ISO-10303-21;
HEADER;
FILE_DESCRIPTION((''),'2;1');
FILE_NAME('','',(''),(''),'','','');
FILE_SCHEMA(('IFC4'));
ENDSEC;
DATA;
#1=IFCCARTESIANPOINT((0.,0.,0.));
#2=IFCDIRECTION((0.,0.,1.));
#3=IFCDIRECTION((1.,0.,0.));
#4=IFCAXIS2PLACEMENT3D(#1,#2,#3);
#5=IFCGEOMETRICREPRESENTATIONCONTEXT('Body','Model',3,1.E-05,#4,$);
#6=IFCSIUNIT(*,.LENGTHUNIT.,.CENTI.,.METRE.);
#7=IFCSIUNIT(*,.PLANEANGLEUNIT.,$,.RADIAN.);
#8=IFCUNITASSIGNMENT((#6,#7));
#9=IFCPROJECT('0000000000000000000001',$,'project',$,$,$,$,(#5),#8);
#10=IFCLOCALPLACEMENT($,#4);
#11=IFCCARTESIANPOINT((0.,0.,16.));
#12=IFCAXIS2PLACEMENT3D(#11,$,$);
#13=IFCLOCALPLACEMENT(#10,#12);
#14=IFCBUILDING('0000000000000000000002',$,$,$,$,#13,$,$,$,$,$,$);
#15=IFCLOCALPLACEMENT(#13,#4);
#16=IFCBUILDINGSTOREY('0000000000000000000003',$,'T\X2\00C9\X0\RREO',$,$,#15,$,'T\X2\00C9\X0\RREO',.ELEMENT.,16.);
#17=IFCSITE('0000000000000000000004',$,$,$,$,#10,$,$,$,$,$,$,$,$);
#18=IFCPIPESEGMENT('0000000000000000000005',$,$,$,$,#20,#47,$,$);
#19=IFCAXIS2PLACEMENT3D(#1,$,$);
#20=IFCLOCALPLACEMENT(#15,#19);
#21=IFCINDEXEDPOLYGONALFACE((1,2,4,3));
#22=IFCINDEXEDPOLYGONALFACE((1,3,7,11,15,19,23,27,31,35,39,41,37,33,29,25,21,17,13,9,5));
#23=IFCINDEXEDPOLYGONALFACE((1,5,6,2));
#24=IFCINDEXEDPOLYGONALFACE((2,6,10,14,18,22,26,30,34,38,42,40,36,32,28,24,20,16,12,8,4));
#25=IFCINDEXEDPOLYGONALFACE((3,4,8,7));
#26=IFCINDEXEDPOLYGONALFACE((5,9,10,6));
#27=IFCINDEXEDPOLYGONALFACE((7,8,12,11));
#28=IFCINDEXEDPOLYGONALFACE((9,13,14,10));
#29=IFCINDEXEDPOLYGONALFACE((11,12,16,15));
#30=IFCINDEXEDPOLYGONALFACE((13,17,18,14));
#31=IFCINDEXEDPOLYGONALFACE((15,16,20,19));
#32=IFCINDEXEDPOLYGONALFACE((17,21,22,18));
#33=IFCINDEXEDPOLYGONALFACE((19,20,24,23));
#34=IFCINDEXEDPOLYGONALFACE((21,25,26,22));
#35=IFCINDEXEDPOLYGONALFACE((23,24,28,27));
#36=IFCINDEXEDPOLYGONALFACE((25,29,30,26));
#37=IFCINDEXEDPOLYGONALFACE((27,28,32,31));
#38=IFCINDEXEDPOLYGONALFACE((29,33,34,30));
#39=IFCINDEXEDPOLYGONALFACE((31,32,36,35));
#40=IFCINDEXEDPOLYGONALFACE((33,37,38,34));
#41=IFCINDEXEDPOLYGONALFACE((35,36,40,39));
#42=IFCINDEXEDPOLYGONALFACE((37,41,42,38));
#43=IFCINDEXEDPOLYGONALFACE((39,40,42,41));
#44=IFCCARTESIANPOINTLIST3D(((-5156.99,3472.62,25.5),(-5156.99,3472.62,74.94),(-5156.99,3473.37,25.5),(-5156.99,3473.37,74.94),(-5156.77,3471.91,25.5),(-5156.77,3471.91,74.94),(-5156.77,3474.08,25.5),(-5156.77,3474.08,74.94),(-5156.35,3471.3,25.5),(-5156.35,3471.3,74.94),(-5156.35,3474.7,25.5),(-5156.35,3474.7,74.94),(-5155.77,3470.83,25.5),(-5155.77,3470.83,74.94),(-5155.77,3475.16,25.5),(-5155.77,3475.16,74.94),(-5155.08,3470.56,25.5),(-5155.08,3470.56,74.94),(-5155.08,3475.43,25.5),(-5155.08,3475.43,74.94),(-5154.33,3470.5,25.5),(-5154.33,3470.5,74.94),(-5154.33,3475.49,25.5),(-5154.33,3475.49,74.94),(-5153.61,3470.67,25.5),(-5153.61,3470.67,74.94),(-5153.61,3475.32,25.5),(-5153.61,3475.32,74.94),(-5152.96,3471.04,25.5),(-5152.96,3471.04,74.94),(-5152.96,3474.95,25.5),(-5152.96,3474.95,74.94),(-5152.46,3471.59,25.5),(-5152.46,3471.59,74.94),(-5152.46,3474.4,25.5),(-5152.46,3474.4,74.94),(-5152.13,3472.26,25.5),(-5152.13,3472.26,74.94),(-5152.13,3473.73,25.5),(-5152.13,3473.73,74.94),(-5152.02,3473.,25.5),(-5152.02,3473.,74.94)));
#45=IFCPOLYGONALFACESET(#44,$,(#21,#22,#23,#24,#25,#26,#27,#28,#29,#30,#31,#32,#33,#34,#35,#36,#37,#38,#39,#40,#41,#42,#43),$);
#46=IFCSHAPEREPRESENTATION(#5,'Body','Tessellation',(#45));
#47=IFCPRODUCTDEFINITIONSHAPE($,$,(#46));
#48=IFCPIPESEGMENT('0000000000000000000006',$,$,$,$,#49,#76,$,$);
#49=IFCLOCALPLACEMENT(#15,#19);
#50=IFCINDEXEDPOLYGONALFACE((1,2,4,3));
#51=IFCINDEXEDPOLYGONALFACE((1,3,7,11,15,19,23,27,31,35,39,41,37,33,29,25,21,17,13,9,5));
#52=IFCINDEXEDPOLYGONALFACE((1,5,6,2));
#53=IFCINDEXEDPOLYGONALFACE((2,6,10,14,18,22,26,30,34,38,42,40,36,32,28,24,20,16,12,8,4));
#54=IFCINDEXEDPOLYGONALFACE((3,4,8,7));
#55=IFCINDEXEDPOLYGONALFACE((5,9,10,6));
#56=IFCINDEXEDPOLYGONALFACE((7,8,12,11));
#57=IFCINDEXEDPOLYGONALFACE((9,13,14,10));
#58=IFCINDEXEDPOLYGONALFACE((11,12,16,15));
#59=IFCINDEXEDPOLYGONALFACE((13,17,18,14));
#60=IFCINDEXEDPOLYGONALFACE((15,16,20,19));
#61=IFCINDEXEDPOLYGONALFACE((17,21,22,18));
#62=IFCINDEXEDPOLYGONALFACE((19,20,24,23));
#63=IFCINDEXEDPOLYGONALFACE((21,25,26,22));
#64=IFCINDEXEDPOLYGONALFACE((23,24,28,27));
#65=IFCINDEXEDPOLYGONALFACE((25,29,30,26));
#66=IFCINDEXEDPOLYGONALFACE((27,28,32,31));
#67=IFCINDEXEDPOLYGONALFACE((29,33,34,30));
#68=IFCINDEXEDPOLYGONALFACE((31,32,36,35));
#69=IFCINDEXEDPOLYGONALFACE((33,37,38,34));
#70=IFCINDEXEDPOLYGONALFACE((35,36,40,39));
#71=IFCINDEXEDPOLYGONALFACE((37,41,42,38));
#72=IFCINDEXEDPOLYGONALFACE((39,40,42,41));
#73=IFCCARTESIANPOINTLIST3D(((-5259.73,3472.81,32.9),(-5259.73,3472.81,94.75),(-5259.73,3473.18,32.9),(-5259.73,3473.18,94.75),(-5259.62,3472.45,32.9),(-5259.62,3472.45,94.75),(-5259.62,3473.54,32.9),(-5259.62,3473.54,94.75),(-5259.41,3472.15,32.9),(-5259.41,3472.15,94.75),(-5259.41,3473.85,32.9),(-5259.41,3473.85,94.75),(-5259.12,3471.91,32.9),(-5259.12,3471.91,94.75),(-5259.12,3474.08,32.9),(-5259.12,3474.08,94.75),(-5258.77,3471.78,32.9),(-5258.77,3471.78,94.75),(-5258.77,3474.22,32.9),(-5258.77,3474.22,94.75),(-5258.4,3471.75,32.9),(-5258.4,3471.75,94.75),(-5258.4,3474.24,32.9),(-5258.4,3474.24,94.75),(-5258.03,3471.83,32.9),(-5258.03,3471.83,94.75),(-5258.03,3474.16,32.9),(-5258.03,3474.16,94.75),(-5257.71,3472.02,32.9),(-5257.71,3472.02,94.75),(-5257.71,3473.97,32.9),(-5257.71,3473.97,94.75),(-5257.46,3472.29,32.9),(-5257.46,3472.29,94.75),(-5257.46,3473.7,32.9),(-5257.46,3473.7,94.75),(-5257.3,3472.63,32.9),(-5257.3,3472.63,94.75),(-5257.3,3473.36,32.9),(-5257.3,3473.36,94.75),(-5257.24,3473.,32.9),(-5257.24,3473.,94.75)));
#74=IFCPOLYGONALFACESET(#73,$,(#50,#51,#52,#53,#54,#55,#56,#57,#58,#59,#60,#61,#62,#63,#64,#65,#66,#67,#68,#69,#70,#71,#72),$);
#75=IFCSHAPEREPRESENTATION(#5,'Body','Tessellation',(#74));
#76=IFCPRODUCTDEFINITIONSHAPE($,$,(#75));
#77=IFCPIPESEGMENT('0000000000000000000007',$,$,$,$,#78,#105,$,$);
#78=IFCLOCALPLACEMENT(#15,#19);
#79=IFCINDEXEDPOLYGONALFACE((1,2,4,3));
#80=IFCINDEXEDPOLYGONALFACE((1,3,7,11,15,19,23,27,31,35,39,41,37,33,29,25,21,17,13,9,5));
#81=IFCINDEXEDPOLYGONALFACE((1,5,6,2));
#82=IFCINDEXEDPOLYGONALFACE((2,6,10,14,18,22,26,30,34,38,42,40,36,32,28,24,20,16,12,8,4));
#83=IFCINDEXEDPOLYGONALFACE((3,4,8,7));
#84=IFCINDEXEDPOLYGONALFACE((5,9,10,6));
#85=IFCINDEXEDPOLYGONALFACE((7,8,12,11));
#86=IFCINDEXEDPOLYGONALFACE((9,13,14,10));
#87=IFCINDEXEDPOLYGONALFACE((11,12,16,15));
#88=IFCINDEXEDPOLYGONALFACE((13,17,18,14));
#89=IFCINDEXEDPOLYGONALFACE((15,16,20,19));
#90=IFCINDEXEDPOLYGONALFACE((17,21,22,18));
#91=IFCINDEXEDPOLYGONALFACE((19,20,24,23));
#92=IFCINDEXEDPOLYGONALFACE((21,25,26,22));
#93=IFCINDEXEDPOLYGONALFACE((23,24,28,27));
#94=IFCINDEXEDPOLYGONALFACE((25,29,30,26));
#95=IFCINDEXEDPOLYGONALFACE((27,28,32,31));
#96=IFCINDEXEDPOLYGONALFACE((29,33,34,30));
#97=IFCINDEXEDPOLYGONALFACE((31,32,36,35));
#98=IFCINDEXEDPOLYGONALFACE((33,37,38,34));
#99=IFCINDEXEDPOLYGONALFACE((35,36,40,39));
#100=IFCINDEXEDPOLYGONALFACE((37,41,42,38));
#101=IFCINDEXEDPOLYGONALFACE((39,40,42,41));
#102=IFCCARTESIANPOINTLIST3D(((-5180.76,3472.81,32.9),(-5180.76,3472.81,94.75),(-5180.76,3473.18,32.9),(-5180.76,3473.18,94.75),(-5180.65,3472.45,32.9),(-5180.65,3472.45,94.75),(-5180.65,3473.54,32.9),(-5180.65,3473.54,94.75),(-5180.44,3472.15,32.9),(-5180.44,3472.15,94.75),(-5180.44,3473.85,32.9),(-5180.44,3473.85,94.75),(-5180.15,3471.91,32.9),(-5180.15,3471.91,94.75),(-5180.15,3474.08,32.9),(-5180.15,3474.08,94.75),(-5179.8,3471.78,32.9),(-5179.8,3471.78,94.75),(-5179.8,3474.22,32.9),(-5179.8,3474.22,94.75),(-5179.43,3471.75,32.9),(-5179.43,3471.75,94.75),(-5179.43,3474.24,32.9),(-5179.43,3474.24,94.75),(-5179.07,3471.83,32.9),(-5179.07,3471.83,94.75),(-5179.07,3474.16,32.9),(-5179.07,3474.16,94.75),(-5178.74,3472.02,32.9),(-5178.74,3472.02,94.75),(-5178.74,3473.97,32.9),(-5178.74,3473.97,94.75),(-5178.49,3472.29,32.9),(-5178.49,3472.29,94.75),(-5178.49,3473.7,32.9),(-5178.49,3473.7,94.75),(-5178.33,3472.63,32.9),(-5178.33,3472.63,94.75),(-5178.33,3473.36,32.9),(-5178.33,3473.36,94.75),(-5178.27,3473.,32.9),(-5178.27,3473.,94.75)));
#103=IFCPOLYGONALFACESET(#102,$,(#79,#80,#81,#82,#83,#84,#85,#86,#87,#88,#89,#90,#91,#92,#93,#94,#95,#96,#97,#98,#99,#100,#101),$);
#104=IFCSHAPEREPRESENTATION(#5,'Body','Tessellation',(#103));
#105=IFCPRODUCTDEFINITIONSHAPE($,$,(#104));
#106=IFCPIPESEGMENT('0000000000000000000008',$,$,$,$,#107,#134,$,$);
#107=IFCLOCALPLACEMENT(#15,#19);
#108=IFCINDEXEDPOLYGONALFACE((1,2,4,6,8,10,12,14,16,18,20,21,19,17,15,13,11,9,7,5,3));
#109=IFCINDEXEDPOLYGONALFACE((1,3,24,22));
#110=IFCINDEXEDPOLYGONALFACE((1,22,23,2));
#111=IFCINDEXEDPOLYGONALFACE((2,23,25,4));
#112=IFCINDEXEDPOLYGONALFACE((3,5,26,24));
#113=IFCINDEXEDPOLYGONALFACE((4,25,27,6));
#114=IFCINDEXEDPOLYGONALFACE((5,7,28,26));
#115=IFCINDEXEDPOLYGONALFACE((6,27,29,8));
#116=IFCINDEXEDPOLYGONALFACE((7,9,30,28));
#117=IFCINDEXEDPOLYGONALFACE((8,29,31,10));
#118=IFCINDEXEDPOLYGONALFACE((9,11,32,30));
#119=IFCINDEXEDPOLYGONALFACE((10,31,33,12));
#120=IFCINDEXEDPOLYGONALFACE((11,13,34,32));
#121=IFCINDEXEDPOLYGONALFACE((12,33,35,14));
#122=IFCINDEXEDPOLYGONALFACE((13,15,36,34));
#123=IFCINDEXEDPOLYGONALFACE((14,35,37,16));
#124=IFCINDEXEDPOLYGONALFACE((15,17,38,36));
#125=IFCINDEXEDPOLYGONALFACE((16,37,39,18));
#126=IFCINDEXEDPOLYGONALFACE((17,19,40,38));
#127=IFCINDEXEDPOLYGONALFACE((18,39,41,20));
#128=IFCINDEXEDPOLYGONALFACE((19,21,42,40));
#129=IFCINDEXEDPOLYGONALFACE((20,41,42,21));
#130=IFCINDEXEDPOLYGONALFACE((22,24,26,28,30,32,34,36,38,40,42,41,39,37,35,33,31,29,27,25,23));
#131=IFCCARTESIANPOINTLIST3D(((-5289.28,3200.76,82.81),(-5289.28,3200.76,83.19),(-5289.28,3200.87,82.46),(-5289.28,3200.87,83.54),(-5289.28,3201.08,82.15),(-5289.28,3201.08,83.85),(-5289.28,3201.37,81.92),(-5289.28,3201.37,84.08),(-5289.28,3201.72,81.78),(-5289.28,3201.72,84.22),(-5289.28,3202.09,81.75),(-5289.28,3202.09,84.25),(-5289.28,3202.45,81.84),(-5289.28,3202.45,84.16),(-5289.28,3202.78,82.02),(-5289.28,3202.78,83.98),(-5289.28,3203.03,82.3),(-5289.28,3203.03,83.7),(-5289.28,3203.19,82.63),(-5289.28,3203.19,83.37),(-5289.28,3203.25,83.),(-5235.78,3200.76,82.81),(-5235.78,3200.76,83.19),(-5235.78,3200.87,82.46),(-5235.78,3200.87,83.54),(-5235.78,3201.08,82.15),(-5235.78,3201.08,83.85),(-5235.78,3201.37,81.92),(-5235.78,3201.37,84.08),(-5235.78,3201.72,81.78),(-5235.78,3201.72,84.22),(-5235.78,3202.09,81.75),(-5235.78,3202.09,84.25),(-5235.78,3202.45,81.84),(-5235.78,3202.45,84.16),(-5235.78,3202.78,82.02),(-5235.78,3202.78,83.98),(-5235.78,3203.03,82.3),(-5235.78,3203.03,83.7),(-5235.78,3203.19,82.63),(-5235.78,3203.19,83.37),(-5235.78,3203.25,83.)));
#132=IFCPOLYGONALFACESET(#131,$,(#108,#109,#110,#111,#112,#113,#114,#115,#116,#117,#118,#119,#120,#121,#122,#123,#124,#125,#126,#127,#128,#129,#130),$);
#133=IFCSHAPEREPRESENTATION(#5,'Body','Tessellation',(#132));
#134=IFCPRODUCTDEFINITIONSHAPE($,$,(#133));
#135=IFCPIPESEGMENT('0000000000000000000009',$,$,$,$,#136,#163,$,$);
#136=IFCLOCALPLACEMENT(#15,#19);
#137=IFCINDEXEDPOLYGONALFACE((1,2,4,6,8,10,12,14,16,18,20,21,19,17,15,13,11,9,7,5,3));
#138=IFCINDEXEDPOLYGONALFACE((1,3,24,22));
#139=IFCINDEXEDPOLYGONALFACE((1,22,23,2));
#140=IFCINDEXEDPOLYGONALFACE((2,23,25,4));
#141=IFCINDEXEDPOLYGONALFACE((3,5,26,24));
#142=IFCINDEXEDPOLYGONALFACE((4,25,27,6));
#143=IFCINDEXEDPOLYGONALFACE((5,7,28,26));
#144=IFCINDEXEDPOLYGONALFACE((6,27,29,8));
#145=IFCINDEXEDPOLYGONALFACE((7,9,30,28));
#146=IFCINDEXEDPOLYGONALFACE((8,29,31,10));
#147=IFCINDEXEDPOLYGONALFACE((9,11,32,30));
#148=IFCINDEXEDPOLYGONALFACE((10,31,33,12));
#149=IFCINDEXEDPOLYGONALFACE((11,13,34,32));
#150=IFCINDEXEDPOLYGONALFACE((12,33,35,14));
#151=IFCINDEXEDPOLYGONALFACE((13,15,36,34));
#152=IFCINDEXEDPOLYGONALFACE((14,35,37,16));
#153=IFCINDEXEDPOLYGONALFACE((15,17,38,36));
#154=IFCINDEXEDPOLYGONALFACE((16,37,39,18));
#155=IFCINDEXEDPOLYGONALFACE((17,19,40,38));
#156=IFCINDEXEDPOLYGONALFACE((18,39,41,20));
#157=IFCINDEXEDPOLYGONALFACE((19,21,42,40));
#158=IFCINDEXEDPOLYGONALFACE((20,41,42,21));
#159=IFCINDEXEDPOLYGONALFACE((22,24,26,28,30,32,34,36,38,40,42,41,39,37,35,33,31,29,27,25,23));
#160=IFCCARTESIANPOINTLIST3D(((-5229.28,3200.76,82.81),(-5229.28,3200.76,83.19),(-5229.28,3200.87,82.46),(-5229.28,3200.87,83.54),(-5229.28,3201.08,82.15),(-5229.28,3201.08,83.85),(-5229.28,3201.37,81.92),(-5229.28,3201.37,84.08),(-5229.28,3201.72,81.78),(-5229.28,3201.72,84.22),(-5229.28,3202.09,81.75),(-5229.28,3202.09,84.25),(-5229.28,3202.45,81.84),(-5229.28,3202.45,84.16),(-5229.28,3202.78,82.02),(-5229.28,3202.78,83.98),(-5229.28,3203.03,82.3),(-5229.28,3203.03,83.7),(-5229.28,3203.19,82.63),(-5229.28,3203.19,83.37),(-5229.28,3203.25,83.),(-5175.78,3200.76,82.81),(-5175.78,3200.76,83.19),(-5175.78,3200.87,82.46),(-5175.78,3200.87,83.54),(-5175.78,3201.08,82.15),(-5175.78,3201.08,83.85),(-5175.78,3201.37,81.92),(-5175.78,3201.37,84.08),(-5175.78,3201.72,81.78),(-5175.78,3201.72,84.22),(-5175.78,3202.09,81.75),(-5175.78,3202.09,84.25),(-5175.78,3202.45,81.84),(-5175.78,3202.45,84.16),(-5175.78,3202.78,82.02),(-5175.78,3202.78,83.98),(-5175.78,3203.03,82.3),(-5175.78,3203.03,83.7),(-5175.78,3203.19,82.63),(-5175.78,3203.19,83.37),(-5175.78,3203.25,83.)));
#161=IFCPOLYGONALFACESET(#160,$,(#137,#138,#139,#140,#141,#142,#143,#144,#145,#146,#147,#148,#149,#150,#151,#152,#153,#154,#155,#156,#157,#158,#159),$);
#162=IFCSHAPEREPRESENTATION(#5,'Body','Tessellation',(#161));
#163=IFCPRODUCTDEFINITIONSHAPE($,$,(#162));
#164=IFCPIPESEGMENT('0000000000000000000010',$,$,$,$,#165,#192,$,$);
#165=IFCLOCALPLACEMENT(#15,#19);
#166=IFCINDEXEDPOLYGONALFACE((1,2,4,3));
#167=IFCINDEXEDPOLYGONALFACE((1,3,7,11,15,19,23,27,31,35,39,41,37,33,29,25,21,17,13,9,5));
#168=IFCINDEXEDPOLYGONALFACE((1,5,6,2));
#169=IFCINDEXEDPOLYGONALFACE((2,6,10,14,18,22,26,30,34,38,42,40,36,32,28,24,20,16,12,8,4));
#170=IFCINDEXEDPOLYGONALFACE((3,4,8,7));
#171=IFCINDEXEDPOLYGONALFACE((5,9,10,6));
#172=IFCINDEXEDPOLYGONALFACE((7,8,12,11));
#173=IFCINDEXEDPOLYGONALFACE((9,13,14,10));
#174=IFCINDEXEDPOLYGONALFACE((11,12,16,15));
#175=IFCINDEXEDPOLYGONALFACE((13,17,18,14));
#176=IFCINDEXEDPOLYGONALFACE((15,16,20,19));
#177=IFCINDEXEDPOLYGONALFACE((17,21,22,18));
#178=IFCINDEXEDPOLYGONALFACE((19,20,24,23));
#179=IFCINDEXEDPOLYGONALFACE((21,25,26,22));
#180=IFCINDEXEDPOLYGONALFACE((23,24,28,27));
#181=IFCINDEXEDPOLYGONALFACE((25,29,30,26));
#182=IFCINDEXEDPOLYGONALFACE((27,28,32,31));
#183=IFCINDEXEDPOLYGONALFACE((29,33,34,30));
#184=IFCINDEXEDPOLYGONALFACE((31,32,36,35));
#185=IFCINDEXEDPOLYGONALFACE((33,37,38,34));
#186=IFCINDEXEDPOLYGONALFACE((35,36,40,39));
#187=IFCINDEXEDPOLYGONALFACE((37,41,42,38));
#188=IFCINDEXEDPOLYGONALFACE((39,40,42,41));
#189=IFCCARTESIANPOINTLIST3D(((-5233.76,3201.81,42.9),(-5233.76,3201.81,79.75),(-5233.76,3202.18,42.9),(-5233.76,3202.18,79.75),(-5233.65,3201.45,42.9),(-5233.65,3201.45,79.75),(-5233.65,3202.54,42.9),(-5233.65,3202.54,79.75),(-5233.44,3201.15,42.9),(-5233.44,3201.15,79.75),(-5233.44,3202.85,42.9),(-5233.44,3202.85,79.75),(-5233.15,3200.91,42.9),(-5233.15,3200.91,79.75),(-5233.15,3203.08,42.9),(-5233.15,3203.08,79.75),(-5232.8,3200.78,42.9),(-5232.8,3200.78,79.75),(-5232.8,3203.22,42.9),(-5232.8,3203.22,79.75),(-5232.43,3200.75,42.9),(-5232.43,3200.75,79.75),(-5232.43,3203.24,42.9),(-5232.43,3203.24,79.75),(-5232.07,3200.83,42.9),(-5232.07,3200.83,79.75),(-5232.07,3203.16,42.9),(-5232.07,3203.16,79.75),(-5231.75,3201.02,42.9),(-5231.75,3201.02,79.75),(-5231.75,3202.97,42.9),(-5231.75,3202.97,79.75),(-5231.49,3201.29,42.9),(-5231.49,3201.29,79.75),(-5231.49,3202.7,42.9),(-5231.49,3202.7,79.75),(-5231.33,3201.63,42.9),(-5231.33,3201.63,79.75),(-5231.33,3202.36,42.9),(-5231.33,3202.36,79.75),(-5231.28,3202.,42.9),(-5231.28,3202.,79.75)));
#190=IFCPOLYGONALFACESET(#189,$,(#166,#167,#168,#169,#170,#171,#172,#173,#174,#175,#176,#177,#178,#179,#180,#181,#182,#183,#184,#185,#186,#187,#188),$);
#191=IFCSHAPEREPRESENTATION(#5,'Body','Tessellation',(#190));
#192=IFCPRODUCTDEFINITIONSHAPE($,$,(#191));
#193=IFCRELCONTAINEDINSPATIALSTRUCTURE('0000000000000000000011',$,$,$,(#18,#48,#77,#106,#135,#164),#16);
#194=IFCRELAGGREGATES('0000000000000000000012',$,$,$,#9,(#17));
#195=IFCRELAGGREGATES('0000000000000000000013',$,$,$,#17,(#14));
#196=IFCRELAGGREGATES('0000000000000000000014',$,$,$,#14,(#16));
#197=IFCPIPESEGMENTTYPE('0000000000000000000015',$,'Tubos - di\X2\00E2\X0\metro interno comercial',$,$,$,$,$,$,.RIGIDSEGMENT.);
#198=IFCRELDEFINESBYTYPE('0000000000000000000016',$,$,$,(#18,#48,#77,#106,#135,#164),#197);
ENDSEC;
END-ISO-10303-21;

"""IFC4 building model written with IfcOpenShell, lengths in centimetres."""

from ifc_helpers import new_model, si_unit, frame, origin_with_axes, origin_2d_with_axis, place, context, project, spatial, circle, extrude, type_object, element, save


model = new_model("IFC4")

# Units and contexts
model_context = context("Model", 3, precision=1e-05, world=origin_with_axes(), identifier="Body")
ifc_project = project(units=[si_unit("LENGTHUNIT", "METRE", prefix="CENTI"), si_unit("PLANEANGLEUNIT", "RADIAN")], contexts=[model_context])

# Site, building, storey
site_placement = place(None, origin_with_axes())
site = spatial("IfcSite", under=ifc_project, at=site_placement)
building_placement = place(site_placement, frame((0.0, 0.0, 16.0)))
building = spatial("IfcBuilding", under=site, at=building_placement)
storey_placement = place(building_placement, origin_with_axes())
storey = spatial("IfcBuildingStorey", under=building, at=storey_placement, Name="TÉRREO", LongName="TÉRREO", CompositionType="ELEMENT", Elevation=16.0)

# Pipe segments
pipe_segment_type = type_object("IfcPipeSegmentType", Name="Tubos - diâmetro interno comercial", PredefinedType="RIGIDSEGMENT")
for number, where, z_axis, x_axis in (
    (1, (-5154.52, 3473.0, 74.94), (0.0, 0.0, 1.0), (1.0, 0.0, 0.0)),
):
    element("IfcPipeSegment", number, at=place(storey_placement, frame(where, z_axis=z_axis, x_axis=x_axis)), inside=storey, type_object=pipe_segment_type, context=model_context, shape_type="SolidModel", body=[
        extrude(circle(Radius=2.5, at=origin_2d_with_axis()), frame((0.0, 0.0, 0.0), z_axis=(0.0, 0.0, -1.0), x_axis=(1.0, 0.0, 0.0)), (0.0, 0.0, 1.0), 49.44),
    ])
for number, where, z_axis, x_axis in (
    (2, (-5258.49, 3473.0, 94.75), (0.0, 0.0, 1.0), (1.0, 0.0, 0.0)),
    (3, (-5179.52, 3473.0, 94.75), (0.0, 0.0, 1.0), (1.0, 0.0, 0.0)),
):
    element("IfcPipeSegment", number, at=place(storey_placement, frame(where, z_axis=z_axis, x_axis=x_axis)), inside=storey, type_object=pipe_segment_type, context=model_context, shape_type="SolidModel", body=[
        extrude(circle(Radius=1.25, at=origin_2d_with_axis()), frame((0.0, 0.0, 0.0), z_axis=(0.0, 0.0, -1.0), x_axis=(1.0, 0.0, 0.0)), (0.0, 0.0, 1.0), 61.85),
    ])
for number, where, z_axis, x_axis in (
    (4, (-5262.53, 3202.0, 84.25), (0.0, 0.0, 1.0), (1.0, 0.0, 0.0)),
    (5, (-5202.53, 3202.0, 84.25), (0.0, 0.0, 1.0), (1.0, 0.0, 0.0)),
):
    element("IfcPipeSegment", number, at=place(storey_placement, frame(where, z_axis=z_axis, x_axis=x_axis)), inside=storey, type_object=pipe_segment_type, context=model_context, shape_type="SolidModel", body=[
        extrude(circle(Radius=1.25, at=origin_2d_with_axis()), frame((-26.75, 0.0, -1.25), z_axis=(1.0, 0.0, 0.0), x_axis=(0.0, 1.0, 0.0)), (0.0, 0.0, 1.0), 53.5),
    ])
for number, where, z_axis, x_axis in (
    (6, (-5232.53, 3202.0, 79.75), (0.0, 0.0, 1.0), (1.0, 0.0, 0.0)),
):
    element("IfcPipeSegment", number, at=place(storey_placement, frame(where, z_axis=z_axis, x_axis=x_axis)), inside=storey, type_object=pipe_segment_type, context=model_context, shape_type="SolidModel", body=[
        extrude(circle(Radius=1.25, at=origin_2d_with_axis()), frame((0.0, 0.0, 0.0), z_axis=(0.0, 0.0, -1.0), x_axis=(1.0, 0.0, 0.0)), (0.0, 0.0, 1.0), 36.85),
    ])

save(model, "model.ifc")
